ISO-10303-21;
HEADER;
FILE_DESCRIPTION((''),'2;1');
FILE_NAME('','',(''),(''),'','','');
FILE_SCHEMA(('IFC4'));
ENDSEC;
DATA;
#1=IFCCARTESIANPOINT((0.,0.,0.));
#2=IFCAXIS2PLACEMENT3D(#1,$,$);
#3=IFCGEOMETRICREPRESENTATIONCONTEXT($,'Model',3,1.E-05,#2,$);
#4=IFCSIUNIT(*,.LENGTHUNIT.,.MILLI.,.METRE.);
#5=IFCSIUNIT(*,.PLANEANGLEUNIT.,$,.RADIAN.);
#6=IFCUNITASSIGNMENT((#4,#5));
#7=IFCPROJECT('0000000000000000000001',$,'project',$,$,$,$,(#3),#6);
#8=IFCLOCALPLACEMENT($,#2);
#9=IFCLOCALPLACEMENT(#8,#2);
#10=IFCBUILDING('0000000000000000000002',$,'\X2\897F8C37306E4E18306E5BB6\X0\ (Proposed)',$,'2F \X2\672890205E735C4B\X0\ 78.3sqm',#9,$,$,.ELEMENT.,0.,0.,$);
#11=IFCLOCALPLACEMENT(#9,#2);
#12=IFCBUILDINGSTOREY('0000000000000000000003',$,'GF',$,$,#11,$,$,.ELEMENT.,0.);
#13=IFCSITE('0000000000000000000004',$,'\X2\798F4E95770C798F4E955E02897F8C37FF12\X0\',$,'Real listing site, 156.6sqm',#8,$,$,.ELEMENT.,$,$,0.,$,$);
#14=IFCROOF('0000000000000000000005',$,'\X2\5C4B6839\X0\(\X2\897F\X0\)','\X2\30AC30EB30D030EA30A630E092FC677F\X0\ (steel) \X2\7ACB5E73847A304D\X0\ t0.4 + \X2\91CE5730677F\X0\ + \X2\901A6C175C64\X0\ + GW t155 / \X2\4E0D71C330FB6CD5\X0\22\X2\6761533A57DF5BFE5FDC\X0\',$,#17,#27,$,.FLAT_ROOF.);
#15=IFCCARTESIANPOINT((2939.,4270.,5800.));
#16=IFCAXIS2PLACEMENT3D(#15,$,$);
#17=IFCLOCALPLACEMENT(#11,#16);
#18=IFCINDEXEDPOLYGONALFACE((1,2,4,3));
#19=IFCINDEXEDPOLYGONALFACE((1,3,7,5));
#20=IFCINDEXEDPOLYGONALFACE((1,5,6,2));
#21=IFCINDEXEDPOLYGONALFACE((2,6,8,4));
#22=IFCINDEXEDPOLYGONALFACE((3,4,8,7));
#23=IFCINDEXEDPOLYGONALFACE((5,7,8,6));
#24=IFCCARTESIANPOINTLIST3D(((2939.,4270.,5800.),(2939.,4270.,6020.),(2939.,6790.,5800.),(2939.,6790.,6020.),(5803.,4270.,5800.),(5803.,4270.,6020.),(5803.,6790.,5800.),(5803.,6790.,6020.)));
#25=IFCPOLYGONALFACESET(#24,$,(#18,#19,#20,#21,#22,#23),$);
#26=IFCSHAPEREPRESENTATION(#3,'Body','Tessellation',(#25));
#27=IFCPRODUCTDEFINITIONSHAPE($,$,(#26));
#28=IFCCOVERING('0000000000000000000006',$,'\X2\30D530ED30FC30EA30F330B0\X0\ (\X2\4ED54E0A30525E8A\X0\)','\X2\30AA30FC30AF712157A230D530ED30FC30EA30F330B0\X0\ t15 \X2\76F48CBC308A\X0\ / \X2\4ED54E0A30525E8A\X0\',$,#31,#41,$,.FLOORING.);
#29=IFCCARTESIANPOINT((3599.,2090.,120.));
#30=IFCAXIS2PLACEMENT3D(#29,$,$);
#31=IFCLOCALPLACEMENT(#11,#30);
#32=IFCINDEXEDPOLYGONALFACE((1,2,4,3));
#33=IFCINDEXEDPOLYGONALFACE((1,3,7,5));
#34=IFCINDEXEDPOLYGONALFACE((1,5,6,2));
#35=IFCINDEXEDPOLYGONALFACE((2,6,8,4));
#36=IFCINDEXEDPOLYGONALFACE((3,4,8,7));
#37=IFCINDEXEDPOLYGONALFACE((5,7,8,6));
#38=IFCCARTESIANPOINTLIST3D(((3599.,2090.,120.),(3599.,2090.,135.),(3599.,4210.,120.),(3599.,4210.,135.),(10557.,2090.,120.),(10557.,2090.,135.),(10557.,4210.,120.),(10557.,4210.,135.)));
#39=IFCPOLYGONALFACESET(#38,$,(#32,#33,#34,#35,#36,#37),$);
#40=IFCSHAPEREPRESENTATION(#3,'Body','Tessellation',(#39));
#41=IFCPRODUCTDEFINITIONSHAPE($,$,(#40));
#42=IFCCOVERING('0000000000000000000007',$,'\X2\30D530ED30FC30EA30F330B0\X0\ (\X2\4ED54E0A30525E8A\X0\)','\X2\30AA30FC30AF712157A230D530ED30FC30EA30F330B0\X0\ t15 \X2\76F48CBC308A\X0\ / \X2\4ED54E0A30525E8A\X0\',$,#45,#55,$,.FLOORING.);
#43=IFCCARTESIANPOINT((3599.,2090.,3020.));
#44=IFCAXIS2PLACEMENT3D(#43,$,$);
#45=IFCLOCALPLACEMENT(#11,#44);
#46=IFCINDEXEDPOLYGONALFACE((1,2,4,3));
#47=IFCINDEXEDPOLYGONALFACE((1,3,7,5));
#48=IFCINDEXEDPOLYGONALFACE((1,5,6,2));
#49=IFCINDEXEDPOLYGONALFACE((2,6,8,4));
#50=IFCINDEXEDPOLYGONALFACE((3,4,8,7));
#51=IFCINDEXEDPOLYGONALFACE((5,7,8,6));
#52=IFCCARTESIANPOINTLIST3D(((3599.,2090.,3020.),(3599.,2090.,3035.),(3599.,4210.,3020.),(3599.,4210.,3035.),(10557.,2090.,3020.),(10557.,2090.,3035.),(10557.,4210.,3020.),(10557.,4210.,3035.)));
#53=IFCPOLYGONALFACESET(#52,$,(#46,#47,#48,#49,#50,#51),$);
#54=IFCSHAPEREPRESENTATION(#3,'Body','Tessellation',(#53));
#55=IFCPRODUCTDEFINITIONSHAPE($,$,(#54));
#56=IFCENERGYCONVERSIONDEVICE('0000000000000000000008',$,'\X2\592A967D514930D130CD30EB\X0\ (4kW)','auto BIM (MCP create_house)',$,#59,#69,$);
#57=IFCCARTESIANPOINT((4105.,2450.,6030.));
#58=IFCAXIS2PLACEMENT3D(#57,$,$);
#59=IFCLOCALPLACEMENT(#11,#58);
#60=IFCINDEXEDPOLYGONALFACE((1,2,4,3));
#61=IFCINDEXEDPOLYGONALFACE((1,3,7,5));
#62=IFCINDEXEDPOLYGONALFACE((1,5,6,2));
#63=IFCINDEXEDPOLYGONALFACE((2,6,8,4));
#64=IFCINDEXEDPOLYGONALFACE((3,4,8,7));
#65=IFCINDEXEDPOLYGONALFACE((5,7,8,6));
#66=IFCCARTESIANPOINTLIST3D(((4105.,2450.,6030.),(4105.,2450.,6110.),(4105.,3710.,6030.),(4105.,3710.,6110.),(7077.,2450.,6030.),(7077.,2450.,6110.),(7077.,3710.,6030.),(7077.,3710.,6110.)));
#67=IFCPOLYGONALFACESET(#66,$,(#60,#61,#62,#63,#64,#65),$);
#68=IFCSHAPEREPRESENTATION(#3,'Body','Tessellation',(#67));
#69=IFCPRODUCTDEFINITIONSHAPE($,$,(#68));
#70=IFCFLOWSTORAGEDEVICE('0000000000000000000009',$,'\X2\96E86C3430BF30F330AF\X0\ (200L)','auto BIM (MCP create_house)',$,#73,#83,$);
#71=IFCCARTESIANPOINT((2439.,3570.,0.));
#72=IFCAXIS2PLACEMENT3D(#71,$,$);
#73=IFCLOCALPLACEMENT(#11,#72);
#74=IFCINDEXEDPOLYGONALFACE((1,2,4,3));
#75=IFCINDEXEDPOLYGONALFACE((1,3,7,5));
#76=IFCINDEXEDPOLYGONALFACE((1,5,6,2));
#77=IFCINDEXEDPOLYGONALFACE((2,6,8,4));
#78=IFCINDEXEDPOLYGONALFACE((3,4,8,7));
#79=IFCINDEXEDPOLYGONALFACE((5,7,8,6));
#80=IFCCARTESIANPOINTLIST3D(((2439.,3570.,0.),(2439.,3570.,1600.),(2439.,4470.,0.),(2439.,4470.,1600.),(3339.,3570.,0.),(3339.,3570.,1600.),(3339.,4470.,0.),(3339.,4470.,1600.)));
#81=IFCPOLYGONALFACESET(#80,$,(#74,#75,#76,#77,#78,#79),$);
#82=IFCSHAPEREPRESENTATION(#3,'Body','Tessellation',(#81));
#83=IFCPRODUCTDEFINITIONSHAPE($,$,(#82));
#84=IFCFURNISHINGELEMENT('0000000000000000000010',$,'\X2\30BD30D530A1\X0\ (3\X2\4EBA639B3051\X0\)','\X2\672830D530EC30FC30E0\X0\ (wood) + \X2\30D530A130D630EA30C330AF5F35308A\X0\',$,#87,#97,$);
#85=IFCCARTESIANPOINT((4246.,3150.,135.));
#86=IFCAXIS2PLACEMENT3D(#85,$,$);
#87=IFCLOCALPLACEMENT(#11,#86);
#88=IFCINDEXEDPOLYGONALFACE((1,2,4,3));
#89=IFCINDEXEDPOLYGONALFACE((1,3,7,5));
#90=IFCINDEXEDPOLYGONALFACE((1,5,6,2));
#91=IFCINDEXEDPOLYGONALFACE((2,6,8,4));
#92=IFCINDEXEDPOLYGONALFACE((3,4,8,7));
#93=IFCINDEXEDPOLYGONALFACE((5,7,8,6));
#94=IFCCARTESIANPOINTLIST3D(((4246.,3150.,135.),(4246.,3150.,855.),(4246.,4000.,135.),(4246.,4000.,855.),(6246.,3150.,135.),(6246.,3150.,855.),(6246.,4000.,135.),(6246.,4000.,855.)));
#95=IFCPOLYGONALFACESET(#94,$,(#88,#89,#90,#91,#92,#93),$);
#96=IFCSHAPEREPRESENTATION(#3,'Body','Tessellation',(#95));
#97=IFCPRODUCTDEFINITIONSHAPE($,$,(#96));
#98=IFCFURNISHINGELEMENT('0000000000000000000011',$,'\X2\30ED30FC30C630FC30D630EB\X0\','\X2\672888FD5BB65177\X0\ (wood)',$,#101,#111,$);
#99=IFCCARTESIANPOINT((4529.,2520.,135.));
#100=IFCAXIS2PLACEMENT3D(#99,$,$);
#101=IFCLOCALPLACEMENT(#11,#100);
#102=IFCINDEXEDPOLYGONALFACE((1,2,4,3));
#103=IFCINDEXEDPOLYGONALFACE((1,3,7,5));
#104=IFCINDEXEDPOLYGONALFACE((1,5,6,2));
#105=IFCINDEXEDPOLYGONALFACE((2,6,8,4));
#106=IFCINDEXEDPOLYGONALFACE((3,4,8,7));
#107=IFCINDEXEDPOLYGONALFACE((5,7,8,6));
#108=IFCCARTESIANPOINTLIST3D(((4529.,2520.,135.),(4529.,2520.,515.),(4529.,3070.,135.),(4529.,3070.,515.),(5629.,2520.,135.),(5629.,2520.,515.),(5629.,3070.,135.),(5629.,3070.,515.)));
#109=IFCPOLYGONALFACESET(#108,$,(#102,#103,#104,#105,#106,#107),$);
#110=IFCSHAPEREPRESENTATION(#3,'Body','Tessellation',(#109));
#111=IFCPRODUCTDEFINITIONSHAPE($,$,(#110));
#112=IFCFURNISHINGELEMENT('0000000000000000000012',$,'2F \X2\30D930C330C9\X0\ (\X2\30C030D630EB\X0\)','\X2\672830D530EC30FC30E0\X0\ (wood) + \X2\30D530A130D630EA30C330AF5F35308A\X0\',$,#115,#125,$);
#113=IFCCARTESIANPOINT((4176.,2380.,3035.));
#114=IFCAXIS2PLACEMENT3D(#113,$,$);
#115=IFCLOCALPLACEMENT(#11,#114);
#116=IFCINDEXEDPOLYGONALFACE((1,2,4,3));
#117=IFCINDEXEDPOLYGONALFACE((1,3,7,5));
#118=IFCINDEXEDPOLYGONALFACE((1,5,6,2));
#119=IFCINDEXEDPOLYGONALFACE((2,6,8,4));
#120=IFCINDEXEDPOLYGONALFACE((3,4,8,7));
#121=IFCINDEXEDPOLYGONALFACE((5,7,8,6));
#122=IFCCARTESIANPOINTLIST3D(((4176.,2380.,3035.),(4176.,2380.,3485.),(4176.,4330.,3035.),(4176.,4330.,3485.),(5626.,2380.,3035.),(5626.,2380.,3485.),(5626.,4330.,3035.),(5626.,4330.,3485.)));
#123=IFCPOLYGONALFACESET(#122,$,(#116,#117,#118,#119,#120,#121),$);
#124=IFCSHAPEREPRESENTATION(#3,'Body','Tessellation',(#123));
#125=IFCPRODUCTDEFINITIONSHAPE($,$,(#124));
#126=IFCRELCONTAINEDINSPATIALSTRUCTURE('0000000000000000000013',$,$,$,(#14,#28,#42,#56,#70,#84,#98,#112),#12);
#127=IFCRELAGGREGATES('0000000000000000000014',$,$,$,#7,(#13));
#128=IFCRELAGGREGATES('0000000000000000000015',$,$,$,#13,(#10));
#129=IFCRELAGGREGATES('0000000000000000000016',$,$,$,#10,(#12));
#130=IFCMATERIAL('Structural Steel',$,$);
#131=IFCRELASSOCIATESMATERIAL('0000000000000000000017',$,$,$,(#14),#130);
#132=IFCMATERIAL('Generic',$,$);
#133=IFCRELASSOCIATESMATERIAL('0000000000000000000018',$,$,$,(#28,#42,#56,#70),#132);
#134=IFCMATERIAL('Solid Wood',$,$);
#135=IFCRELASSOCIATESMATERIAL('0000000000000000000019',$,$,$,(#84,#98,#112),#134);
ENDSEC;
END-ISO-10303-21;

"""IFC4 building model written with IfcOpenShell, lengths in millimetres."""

from ifc_helpers import new_model, si_unit, frame, frame_2d, origin, place, context, project, spatial, rectangle, extrude, material, element, save


model = new_model("IFC4")

# Units and contexts
model_context = context("Model", 3, precision=1e-05, world=origin())
ifc_project = project(units=[si_unit("LENGTHUNIT", "METRE", prefix="MILLI"), si_unit("PLANEANGLEUNIT", "RADIAN")], contexts=[model_context])

# Site, building, storey
site_placement = place(None, origin())
site = spatial("IfcSite", under=ifc_project, at=site_placement, Name="福井県福井市西谷２", ObjectType="Real listing site, 156.6sqm", CompositionType="ELEMENT", RefElevation=0.0)
building_placement = place(site_placement, origin())
building = spatial("IfcBuilding", under=site, at=building_placement, Name="西谷の丘の家 (Proposed)", ObjectType="2F 木造平屋 78.3sqm", CompositionType="ELEMENT", ElevationOfRefHeight=0.0, ElevationOfTerrain=0.0)
storey_placement = place(building_placement, origin())
storey = spatial("IfcBuildingStorey", under=building, at=storey_placement, Name="GF", CompositionType="ELEMENT", Elevation=0.0)

# Shared definitions
ifc_material_1 = material(Name="Solid Wood")

# Roof
ifc_material_2 = material(Name="Structural Steel")
roof_1_placement = place(storey_placement, frame((2939.0, 4270.0, 5800.0)))
element("IfcRoof", 1, at=roof_1_placement, inside=storey, material=ifc_material_2, Name="屋根(西)", Description="ガルバリウム鋼板 (steel) 立平葺き t0.4 + 野地板 + 通気層 + GW t155 / 不燃・法22条区域対応", PredefinedType="FLAT_ROOF", context=model_context, shape_type="SweptSolid", body=[
    extrude(rectangle(XDim=2864.0, YDim=2520.0, at=frame_2d((1432.0, 1260.0))), frame((2939.0, 4270.0, 5800.0)), (0.0, 0.0, 1.0), 220.0),
])

# Coverings
ifc_material_3 = material(Name="Generic")
covering_1_placement = place(storey_placement, frame((3599.0, 2090.0, 120.0)))
element("IfcCovering", 2, at=covering_1_placement, inside=storey, material=ifc_material_3, Name="フローリング (仕上げ床)", Description="オーク無垢フローリング t15 直貼り / 仕上げ床", PredefinedType="FLOORING", context=model_context, shape_type="SweptSolid", body=[
    extrude(rectangle(XDim=6958.0, YDim=2120.0, at=frame_2d((3479.0, 1060.0))), frame((3599.0, 2090.0, 120.0)), (0.0, 0.0, 1.0), 15.0),
])
covering_2_placement = place(storey_placement, frame((3599.0, 2090.0, 3020.0)))
element("IfcCovering", 3, at=covering_2_placement, inside=storey, material=ifc_material_3, Name="フローリング (仕上げ床)", Description="オーク無垢フローリング t15 直貼り / 仕上げ床", PredefinedType="FLOORING", context=model_context, shape_type="SweptSolid", body=[
    extrude(rectangle(XDim=6958.0, YDim=2120.0, at=frame_2d((3479.0, 1060.0))), frame((3599.0, 2090.0, 3020.0)), (0.0, 0.0, 1.0), 15.0),
])

# Energy conversion device
energy_conversion_device_placement = place(storey_placement, frame((4105.0, 2450.0, 6030.0)))
element("IfcEnergyConversionDevice", 4, at=energy_conversion_device_placement, inside=storey, material=ifc_material_3, Name="太陽光パネル (4kW)", Description="auto BIM (MCP create_house)", context=model_context, shape_type="SweptSolid", body=[
    extrude(rectangle(XDim=2972.0, YDim=1260.0, at=frame_2d((1486.0, 630.0))), frame((4105.0, 2450.0, 6030.0)), (0.0, 0.0, 1.0), 80.0),
])

# Flow storage device
flow_storage_device_placement = place(storey_placement, frame((2439.0, 3570.0, 0.0)))
element("IfcFlowStorageDevice", 5, at=flow_storage_device_placement, inside=storey, material=ifc_material_3, Name="雨水タンク (200L)", Description="auto BIM (MCP create_house)", context=model_context, shape_type="SweptSolid", body=[
    extrude(rectangle(XDim=900.0, YDim=900.0, at=frame_2d((450.0, 450.0))), frame((2439.0, 3570.0, 0.0)), (0.0, 0.0, 1.0), 1600.0),
])

# Furnishing elements
furnishing_1_placement = place(storey_placement, frame((4246.0, 3150.0, 135.0)))
element("IfcFurnishingElement", 6, at=furnishing_1_placement, inside=storey, material=ifc_material_1, Name="ソファ (3人掛け)", Description="木フレーム (wood) + ファブリック張り", context=model_context, shape_type="SweptSolid", body=[
    extrude(rectangle(XDim=2000.0, YDim=850.0, at=frame_2d((1000.0, 425.0))), frame((4246.0, 3150.0, 135.0)), (0.0, 0.0, 1.0), 720.0),
])
furnishing_2_placement = place(storey_placement, frame((4529.0, 2520.0, 135.0)))
element("IfcFurnishingElement", 7, at=furnishing_2_placement, inside=storey, material=ifc_material_1, Name="ローテーブル", Description="木製家具 (wood)", context=model_context, shape_type="SweptSolid", body=[
    extrude(rectangle(XDim=1100.0, YDim=550.0, at=frame_2d((550.0, 275.0))), frame((4529.0, 2520.0, 135.0)), (0.0, 0.0, 1.0), 380.0),
])
furnishing_3_placement = place(storey_placement, frame((4176.0, 2380.0, 3035.0)))
element("IfcFurnishingElement", 8, at=furnishing_3_placement, inside=storey, material=ifc_material_1, Name="2F ベッド (ダブル)", Description="木フレーム (wood) + ファブリック張り", context=model_context, shape_type="SweptSolid", body=[
    extrude(rectangle(XDim=1450.0, YDim=1950.0, at=frame_2d((725.0, 975.0))), frame((4176.0, 2380.0, 3035.0)), (0.0, 0.0, 1.0), 450.0),
])

save(model, "model.ifc")
